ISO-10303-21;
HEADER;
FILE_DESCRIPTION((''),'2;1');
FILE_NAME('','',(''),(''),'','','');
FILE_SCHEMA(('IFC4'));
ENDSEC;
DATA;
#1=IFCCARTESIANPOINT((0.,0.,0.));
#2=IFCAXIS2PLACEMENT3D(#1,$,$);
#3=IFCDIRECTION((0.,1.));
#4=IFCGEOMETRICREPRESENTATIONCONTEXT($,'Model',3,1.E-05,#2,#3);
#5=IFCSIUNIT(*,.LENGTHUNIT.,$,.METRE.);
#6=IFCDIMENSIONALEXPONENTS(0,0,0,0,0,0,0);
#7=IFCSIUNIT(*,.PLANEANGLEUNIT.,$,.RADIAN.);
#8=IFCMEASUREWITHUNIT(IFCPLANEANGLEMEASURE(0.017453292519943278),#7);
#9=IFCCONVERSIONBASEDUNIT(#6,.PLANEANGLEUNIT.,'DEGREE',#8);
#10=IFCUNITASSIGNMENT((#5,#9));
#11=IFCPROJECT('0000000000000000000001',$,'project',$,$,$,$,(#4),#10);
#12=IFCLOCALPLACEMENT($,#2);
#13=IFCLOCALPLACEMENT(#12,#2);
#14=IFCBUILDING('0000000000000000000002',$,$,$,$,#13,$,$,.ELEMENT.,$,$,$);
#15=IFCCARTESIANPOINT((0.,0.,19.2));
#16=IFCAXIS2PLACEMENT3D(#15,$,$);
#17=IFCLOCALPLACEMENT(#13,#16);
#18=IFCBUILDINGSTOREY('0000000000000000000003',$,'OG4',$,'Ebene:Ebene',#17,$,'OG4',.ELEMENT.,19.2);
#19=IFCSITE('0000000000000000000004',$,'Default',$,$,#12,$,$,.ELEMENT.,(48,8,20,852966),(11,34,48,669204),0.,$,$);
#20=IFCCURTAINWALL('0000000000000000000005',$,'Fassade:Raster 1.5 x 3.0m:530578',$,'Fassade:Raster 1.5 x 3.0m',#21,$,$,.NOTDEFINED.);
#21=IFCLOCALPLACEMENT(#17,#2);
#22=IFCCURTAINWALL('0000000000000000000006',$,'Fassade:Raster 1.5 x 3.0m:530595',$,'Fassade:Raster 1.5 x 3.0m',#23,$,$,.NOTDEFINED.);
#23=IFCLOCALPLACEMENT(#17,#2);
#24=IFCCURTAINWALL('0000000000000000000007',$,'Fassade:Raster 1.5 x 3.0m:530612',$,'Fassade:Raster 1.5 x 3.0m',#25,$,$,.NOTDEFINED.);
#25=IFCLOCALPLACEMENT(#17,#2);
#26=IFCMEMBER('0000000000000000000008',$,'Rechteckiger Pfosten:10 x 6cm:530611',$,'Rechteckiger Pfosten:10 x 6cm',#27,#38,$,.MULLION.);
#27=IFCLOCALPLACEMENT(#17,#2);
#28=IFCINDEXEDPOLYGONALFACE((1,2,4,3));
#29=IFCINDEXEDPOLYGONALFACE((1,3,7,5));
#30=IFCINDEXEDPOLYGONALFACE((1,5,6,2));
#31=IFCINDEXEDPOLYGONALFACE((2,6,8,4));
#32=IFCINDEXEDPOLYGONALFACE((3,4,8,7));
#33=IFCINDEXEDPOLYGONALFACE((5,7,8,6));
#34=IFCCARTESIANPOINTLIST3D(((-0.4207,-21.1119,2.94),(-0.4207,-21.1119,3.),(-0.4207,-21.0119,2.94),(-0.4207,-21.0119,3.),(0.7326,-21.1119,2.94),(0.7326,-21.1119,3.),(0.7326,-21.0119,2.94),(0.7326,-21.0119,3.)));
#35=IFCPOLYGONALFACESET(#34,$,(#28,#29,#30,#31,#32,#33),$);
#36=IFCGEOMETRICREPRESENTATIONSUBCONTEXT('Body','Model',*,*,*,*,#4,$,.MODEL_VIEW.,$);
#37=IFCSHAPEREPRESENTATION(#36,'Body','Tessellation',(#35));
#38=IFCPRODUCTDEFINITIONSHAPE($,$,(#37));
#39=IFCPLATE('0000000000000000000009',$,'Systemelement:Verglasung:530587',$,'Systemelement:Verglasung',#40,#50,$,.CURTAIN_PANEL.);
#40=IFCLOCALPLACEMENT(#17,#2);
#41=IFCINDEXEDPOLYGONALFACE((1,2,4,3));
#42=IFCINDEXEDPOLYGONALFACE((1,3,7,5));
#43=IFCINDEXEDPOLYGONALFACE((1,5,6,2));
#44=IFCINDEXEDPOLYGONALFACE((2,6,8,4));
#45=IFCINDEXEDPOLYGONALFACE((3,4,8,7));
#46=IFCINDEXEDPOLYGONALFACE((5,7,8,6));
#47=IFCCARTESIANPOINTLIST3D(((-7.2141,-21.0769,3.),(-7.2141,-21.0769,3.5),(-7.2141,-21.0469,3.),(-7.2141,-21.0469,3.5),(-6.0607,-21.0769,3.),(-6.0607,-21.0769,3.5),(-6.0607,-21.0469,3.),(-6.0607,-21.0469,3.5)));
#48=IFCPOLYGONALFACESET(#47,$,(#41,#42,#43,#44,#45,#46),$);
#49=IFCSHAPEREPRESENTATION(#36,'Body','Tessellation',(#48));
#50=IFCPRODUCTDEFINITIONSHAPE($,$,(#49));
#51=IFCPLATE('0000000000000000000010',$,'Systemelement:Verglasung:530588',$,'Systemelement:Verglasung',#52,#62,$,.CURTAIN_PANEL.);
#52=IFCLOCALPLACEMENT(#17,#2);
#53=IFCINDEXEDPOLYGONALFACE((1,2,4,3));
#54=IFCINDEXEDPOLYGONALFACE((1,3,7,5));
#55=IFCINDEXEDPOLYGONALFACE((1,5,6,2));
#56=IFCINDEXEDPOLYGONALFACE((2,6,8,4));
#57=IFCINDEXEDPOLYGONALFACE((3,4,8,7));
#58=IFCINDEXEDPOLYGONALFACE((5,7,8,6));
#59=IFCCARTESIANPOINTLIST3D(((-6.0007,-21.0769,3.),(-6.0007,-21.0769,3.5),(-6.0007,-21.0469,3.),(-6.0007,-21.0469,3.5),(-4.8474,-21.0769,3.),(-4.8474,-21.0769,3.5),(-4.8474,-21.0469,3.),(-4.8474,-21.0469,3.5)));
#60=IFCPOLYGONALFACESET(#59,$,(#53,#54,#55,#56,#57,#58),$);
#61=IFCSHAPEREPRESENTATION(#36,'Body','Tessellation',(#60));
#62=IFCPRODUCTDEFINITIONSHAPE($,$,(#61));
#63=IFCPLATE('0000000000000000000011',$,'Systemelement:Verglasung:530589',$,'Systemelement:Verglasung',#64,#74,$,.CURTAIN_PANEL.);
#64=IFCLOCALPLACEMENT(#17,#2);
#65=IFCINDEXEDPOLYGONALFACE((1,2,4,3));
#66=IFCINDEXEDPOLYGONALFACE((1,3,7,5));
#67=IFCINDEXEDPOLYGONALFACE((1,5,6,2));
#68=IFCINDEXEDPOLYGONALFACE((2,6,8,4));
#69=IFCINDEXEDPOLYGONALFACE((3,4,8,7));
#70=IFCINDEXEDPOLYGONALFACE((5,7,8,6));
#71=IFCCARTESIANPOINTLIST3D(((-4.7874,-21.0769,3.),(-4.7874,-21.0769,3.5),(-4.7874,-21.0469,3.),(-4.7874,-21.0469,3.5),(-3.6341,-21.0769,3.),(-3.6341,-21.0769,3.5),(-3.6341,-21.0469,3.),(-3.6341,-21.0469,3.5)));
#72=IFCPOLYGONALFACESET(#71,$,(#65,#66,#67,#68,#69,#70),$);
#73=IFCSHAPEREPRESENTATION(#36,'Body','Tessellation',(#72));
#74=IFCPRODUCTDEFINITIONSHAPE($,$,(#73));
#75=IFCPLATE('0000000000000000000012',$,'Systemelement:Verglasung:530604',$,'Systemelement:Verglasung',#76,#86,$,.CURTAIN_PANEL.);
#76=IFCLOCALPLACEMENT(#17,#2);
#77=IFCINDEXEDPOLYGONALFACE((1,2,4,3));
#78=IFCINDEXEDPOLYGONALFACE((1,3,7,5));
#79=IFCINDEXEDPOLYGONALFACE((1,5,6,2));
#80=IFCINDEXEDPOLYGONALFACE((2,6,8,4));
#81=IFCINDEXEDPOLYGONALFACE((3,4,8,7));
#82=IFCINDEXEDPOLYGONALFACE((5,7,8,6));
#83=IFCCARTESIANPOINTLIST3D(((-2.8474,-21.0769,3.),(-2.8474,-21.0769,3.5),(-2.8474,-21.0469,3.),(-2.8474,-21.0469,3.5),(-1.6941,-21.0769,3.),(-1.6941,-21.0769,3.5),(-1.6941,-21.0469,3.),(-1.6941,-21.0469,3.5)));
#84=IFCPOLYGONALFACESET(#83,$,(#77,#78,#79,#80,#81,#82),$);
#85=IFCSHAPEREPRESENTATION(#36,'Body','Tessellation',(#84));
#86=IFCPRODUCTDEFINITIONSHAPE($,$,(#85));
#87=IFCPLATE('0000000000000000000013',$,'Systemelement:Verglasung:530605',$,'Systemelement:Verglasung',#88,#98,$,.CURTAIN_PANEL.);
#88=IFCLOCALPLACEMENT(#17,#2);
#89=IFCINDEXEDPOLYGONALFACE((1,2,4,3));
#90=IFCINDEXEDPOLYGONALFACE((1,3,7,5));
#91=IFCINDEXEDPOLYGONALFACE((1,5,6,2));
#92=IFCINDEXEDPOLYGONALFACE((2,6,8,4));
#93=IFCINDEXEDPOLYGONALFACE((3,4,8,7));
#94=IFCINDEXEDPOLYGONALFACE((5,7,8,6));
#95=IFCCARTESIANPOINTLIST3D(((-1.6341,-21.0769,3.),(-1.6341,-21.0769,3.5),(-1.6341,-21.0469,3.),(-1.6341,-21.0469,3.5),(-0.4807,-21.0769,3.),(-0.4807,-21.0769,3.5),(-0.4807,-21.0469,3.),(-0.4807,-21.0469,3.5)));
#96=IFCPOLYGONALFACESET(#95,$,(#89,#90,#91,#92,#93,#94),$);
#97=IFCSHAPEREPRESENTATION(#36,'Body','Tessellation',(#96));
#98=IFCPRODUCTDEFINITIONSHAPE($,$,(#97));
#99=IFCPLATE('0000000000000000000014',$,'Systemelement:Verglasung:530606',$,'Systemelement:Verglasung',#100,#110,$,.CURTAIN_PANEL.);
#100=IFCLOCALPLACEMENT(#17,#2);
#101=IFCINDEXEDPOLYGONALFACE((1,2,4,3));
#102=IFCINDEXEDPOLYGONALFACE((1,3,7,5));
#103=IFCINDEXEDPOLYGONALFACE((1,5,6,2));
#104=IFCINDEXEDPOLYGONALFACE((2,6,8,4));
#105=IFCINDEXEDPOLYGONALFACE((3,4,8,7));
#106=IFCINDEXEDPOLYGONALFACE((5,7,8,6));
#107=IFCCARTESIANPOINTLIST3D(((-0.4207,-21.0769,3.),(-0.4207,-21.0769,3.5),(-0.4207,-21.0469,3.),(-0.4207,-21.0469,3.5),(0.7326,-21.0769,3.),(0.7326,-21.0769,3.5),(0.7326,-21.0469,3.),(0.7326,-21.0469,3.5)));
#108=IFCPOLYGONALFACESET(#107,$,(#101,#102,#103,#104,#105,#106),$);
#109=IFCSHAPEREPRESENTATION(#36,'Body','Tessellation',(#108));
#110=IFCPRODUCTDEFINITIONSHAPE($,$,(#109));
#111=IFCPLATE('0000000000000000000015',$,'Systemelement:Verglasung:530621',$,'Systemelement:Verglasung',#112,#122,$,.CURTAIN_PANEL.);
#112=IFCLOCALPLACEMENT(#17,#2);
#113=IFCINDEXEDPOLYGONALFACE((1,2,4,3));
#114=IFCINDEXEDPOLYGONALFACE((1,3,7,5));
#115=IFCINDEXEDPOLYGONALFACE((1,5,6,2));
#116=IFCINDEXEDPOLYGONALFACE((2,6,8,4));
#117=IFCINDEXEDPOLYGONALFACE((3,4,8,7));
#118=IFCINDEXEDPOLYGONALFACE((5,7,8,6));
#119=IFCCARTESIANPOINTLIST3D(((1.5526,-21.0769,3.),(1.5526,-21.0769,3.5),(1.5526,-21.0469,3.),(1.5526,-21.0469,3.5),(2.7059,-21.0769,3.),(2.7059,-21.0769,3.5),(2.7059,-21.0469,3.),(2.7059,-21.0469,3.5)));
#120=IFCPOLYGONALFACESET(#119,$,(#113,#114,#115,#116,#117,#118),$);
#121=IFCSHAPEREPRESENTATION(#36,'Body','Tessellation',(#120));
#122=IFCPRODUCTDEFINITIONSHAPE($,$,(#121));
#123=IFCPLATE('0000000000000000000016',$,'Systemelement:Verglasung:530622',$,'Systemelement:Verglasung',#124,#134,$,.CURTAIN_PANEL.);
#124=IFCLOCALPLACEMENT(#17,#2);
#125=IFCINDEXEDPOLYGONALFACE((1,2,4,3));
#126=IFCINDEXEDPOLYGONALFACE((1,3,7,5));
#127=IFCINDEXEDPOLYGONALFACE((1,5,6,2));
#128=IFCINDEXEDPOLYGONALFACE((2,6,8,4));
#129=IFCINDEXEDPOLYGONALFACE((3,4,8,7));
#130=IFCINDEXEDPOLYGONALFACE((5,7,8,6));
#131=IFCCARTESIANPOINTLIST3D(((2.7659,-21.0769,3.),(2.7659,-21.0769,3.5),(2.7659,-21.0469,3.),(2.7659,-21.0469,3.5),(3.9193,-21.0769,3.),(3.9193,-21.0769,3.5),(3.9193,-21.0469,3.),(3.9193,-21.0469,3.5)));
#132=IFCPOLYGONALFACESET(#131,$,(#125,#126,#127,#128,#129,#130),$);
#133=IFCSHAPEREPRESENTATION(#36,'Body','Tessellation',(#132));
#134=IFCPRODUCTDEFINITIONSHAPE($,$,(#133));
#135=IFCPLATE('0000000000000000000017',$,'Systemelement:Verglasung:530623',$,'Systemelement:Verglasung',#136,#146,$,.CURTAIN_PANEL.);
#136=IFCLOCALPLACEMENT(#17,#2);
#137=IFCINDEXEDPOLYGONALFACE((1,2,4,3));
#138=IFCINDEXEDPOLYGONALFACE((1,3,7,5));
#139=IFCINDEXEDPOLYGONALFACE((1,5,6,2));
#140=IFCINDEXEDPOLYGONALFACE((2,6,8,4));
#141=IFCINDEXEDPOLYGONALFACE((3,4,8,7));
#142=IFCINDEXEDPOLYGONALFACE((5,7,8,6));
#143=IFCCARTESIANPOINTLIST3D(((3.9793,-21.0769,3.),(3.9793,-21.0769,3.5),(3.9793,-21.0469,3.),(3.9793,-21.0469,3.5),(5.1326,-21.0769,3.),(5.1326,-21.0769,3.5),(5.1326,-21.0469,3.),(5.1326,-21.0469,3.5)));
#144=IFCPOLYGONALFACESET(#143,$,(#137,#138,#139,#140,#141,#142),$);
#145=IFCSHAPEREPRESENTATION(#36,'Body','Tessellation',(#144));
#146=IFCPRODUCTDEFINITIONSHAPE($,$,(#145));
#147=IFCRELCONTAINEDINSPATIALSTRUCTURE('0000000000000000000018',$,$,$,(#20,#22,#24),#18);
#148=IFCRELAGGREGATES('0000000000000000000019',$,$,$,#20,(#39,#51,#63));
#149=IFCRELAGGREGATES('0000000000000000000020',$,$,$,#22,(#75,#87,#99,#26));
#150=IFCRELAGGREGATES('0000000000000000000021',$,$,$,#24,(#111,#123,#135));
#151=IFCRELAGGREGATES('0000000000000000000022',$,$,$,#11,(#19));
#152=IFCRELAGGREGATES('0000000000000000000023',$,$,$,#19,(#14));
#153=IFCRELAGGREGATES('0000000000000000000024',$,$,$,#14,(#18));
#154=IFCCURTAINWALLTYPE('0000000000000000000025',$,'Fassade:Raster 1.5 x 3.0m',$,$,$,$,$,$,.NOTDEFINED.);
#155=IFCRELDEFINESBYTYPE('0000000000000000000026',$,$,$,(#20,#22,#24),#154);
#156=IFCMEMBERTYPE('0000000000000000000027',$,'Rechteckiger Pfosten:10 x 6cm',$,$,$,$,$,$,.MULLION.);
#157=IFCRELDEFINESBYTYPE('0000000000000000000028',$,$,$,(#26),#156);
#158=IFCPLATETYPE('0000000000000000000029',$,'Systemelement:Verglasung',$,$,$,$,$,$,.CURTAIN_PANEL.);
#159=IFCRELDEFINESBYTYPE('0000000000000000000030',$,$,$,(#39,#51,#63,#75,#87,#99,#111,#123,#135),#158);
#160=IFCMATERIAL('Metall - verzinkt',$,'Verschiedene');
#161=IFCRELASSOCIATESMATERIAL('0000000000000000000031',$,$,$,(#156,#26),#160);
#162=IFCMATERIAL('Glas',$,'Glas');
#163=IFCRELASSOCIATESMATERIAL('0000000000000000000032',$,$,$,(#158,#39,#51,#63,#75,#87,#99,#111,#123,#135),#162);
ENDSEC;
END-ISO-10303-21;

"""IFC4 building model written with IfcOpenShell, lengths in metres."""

from ifc_helpers import new_model, entity, si_unit, converted_unit, direction, frame, origin, place, context, subcontext, project, spatial, indexed_curve, outline, extrude, source, transform, mapped, material, type_object, type_shapes, element, aggregate, save


model = new_model("IFC4")

# Units and contexts
model_context = context("Model", 3, precision=1e-05, world=origin(), true_north=direction((0.0, 1.0)))
body_context = subcontext(model_context, "Body", "Model", "MODEL_VIEW")
ifc_project = project(units=[si_unit("LENGTHUNIT", "METRE"), converted_unit("PLANEANGLEUNIT", "DEGREE", entity("IfcPlaneAngleMeasure", 0.017453292519943278), si_unit("PLANEANGLEUNIT", "RADIAN"), dimensions=[0, 0, 0, 0, 0, 0, 0])], contexts=[model_context])

# Site, building, storey
site_placement = place(None, origin())
site = spatial("IfcSite", under=ifc_project, at=site_placement, Name="Default", CompositionType="ELEMENT", RefLatitude=(48, 8, 20, 852966), RefLongitude=(11, 34, 48, 669204), RefElevation=0.0)
building_placement = place(site_placement, origin())
building = spatial("IfcBuilding", under=site, at=building_placement, CompositionType="ELEMENT")
storey_placement = place(building_placement, frame((0.0, 0.0, 19.2)))
storey = spatial("IfcBuildingStorey", under=building, at=storey_placement, Name="OG4", ObjectType="Ebene:Ebene", LongName="OG4", CompositionType="ELEMENT", Elevation=19.2)

# Curtain walls
curtain_wall_type = type_object("IfcCurtainWallType", Name="Fassade:Raster 1.5 x 3.0m", PredefinedType="NOTDEFINED")
curtain_wall_1_placement = place(storey_placement, frame((0.0, 0.0, -19.2)))
curtain_wall_1 = element("IfcCurtainWall", 1, at=curtain_wall_1_placement, inside=storey, type_object=curtain_wall_type, Name="Fassade:Raster 1.5 x 3.0m:530578", ObjectType="Fassade:Raster 1.5 x 3.0m", PredefinedType="NOTDEFINED")
ifc_material_1 = material(Name="Metall - verzinkt", Category="Verschiedene")
curtain_wall_2_placement = place(storey_placement, frame((0.0, 0.0, -19.2)))
curtain_wall_2 = element("IfcCurtainWall", 2, at=curtain_wall_2_placement, inside=storey, type_object=curtain_wall_type, Name="Fassade:Raster 1.5 x 3.0m:530595", ObjectType="Fassade:Raster 1.5 x 3.0m", PredefinedType="NOTDEFINED")
curtain_wall_3_placement = place(storey_placement, frame((0.0, 0.0, -19.2)))
curtain_wall_3 = element("IfcCurtainWall", 3, at=curtain_wall_3_placement, inside=storey, type_object=curtain_wall_type, Name="Fassade:Raster 1.5 x 3.0m:530612", ObjectType="Fassade:Raster 1.5 x 3.0m", PredefinedType="NOTDEFINED")

# Member
member_type_1 = type_object("IfcMemberType", Name="Rechteckiger Pfosten:10 x 6cm", PredefinedType="MULLION", material=ifc_material_1)
shared_shape_1 = source(origin(), body_context, "Body", "SweptSolid", [
    extrude(outline(indexed_curve([(-0.03, -0.05), (0.03, -0.05), (0.03, 0.05), (-0.03, 0.05), (-0.03, -0.05)], self_intersect=False)), frame((0.0, 0.0, -1.1533), z_axis=(0.0, 0.0, 1.0), x_axis=(-1.0, 0.0, 0.0)), (0.0, 0.0, 1.0), 1.1533),
])
type_shapes(member_type_1, [shared_shape_1])
member_1_placement = place(curtain_wall_2_placement, frame((0.7326, -21.0619, 22.17), z_axis=(1.0, 0.0, 0.0), x_axis=(0.0, 0.0, 1.0)))
member_1 = element("IfcMember", 4, at=member_1_placement, type_object=member_type_1, material=ifc_material_1, Name="Rechteckiger Pfosten:10 x 6cm:530611", ObjectType="Rechteckiger Pfosten:10 x 6cm", PredefinedType="MULLION", context=body_context, shape_type="MappedRepresentation", body=[
    mapped(shared_shape_1, transform((0.0, 0.0, 0.0), scale=1.0)),
])

# Plates
ifc_material_2 = material(Name="Glas", Category="Glas")
plate_type = type_object("IfcPlateType", Name="Systemelement:Verglasung", PredefinedType="CURTAIN_PANEL", material=ifc_material_2)
shared_shape_2 = source(origin(), body_context, "Body", "SweptSolid", [
    extrude(outline(indexed_curve([(-0.015, -0.5767), (0.015, -0.5767), (0.015, 0.5767), (-0.015, 0.5767), (-0.015, -0.5767)], self_intersect=False)), frame((0.0, 0.0, 0.0), z_axis=(0.0, 0.0, 1.0), x_axis=(0.0, 1.0, 0.0)), (0.0, 0.0, 1.0), 0.5),
])
type_shapes(plate_type, [shared_shape_2])
plate_1_placement = place(curtain_wall_1_placement, frame((-6.6374, -21.0619, 22.2)))
plate_1 = element("IfcPlate", 5, at=plate_1_placement, type_object=plate_type, material=ifc_material_2, Name="Systemelement:Verglasung:530587", ObjectType="Systemelement:Verglasung", PredefinedType="CURTAIN_PANEL", context=body_context, shape_type="MappedRepresentation", body=[
    mapped(shared_shape_2, transform((0.0, 0.0, 0.0), scale=1.0)),
])
plate_2_placement = place(curtain_wall_1_placement, frame((-5.4241, -21.0619, 22.2)))
plate_2 = element("IfcPlate", 6, at=plate_2_placement, type_object=plate_type, material=ifc_material_2, Name="Systemelement:Verglasung:530588", ObjectType="Systemelement:Verglasung", PredefinedType="CURTAIN_PANEL", context=body_context, shape_type="MappedRepresentation", body=[
    mapped(shared_shape_2, transform((0.0, 0.0, 0.0), scale=1.0)),
])
plate_3_placement = place(curtain_wall_1_placement, frame((-4.2107, -21.0619, 22.2)))
plate_3 = element("IfcPlate", 7, at=plate_3_placement, type_object=plate_type, material=ifc_material_2, Name="Systemelement:Verglasung:530589", ObjectType="Systemelement:Verglasung", PredefinedType="CURTAIN_PANEL", context=body_context, shape_type="MappedRepresentation", body=[
    mapped(shared_shape_2, transform((0.0, 0.0, 0.0), scale=1.0)),
])
aggregate(curtain_wall_1, [plate_1, plate_2, plate_3])
plate_4_placement = place(curtain_wall_2_placement, frame((-2.2707, -21.0619, 22.2)))
plate_4 = element("IfcPlate", 8, at=plate_4_placement, type_object=plate_type, material=ifc_material_2, Name="Systemelement:Verglasung:530604", ObjectType="Systemelement:Verglasung", PredefinedType="CURTAIN_PANEL", context=body_context, shape_type="MappedRepresentation", body=[
    mapped(shared_shape_2, transform((0.0, 0.0, 0.0), scale=1.0)),
])
plate_5_placement = place(curtain_wall_2_placement, frame((-1.0574, -21.0619, 22.2)))
plate_5 = element("IfcPlate", 9, at=plate_5_placement, type_object=plate_type, material=ifc_material_2, Name="Systemelement:Verglasung:530605", ObjectType="Systemelement:Verglasung", PredefinedType="CURTAIN_PANEL", context=body_context, shape_type="MappedRepresentation", body=[
    mapped(shared_shape_2, transform((0.0, 0.0, 0.0), scale=1.0)),
])
plate_6_placement = place(curtain_wall_2_placement, frame((0.1559, -21.0619, 22.2)))
plate_6 = element("IfcPlate", 10, at=plate_6_placement, type_object=plate_type, material=ifc_material_2, Name="Systemelement:Verglasung:530606", ObjectType="Systemelement:Verglasung", PredefinedType="CURTAIN_PANEL", context=body_context, shape_type="MappedRepresentation", body=[
    mapped(shared_shape_2, transform((0.0, 0.0, 0.0), scale=1.0)),
])
aggregate(curtain_wall_2, [plate_4, plate_5, plate_6, member_1])
plate_7_placement = place(curtain_wall_3_placement, frame((2.1293, -21.0619, 22.2)))
plate_7 = element("IfcPlate", 11, at=plate_7_placement, type_object=plate_type, material=ifc_material_2, Name="Systemelement:Verglasung:530621", ObjectType="Systemelement:Verglasung", PredefinedType="CURTAIN_PANEL", context=body_context, shape_type="MappedRepresentation", body=[
    mapped(shared_shape_2, transform((0.0, 0.0, 0.0), scale=1.0)),
])
plate_8_placement = place(curtain_wall_3_placement, frame((3.3426, -21.0619, 22.2)))
plate_8 = element("IfcPlate", 12, at=plate_8_placement, type_object=plate_type, material=ifc_material_2, Name="Systemelement:Verglasung:530622", ObjectType="Systemelement:Verglasung", PredefinedType="CURTAIN_PANEL", context=body_context, shape_type="MappedRepresentation", body=[
    mapped(shared_shape_2, transform((0.0, 0.0, 0.0), scale=1.0)),
])
plate_9_placement = place(curtain_wall_3_placement, frame((4.5559, -21.0619, 22.2)))
plate_9 = element("IfcPlate", 13, at=plate_9_placement, type_object=plate_type, material=ifc_material_2, Name="Systemelement:Verglasung:530623", ObjectType="Systemelement:Verglasung", PredefinedType="CURTAIN_PANEL", context=body_context, shape_type="MappedRepresentation", body=[
    mapped(shared_shape_2, transform((0.0, 0.0, 0.0), scale=1.0)),
])
aggregate(curtain_wall_3, [plate_7, plate_8, plate_9])

save(model, "model.ifc")
